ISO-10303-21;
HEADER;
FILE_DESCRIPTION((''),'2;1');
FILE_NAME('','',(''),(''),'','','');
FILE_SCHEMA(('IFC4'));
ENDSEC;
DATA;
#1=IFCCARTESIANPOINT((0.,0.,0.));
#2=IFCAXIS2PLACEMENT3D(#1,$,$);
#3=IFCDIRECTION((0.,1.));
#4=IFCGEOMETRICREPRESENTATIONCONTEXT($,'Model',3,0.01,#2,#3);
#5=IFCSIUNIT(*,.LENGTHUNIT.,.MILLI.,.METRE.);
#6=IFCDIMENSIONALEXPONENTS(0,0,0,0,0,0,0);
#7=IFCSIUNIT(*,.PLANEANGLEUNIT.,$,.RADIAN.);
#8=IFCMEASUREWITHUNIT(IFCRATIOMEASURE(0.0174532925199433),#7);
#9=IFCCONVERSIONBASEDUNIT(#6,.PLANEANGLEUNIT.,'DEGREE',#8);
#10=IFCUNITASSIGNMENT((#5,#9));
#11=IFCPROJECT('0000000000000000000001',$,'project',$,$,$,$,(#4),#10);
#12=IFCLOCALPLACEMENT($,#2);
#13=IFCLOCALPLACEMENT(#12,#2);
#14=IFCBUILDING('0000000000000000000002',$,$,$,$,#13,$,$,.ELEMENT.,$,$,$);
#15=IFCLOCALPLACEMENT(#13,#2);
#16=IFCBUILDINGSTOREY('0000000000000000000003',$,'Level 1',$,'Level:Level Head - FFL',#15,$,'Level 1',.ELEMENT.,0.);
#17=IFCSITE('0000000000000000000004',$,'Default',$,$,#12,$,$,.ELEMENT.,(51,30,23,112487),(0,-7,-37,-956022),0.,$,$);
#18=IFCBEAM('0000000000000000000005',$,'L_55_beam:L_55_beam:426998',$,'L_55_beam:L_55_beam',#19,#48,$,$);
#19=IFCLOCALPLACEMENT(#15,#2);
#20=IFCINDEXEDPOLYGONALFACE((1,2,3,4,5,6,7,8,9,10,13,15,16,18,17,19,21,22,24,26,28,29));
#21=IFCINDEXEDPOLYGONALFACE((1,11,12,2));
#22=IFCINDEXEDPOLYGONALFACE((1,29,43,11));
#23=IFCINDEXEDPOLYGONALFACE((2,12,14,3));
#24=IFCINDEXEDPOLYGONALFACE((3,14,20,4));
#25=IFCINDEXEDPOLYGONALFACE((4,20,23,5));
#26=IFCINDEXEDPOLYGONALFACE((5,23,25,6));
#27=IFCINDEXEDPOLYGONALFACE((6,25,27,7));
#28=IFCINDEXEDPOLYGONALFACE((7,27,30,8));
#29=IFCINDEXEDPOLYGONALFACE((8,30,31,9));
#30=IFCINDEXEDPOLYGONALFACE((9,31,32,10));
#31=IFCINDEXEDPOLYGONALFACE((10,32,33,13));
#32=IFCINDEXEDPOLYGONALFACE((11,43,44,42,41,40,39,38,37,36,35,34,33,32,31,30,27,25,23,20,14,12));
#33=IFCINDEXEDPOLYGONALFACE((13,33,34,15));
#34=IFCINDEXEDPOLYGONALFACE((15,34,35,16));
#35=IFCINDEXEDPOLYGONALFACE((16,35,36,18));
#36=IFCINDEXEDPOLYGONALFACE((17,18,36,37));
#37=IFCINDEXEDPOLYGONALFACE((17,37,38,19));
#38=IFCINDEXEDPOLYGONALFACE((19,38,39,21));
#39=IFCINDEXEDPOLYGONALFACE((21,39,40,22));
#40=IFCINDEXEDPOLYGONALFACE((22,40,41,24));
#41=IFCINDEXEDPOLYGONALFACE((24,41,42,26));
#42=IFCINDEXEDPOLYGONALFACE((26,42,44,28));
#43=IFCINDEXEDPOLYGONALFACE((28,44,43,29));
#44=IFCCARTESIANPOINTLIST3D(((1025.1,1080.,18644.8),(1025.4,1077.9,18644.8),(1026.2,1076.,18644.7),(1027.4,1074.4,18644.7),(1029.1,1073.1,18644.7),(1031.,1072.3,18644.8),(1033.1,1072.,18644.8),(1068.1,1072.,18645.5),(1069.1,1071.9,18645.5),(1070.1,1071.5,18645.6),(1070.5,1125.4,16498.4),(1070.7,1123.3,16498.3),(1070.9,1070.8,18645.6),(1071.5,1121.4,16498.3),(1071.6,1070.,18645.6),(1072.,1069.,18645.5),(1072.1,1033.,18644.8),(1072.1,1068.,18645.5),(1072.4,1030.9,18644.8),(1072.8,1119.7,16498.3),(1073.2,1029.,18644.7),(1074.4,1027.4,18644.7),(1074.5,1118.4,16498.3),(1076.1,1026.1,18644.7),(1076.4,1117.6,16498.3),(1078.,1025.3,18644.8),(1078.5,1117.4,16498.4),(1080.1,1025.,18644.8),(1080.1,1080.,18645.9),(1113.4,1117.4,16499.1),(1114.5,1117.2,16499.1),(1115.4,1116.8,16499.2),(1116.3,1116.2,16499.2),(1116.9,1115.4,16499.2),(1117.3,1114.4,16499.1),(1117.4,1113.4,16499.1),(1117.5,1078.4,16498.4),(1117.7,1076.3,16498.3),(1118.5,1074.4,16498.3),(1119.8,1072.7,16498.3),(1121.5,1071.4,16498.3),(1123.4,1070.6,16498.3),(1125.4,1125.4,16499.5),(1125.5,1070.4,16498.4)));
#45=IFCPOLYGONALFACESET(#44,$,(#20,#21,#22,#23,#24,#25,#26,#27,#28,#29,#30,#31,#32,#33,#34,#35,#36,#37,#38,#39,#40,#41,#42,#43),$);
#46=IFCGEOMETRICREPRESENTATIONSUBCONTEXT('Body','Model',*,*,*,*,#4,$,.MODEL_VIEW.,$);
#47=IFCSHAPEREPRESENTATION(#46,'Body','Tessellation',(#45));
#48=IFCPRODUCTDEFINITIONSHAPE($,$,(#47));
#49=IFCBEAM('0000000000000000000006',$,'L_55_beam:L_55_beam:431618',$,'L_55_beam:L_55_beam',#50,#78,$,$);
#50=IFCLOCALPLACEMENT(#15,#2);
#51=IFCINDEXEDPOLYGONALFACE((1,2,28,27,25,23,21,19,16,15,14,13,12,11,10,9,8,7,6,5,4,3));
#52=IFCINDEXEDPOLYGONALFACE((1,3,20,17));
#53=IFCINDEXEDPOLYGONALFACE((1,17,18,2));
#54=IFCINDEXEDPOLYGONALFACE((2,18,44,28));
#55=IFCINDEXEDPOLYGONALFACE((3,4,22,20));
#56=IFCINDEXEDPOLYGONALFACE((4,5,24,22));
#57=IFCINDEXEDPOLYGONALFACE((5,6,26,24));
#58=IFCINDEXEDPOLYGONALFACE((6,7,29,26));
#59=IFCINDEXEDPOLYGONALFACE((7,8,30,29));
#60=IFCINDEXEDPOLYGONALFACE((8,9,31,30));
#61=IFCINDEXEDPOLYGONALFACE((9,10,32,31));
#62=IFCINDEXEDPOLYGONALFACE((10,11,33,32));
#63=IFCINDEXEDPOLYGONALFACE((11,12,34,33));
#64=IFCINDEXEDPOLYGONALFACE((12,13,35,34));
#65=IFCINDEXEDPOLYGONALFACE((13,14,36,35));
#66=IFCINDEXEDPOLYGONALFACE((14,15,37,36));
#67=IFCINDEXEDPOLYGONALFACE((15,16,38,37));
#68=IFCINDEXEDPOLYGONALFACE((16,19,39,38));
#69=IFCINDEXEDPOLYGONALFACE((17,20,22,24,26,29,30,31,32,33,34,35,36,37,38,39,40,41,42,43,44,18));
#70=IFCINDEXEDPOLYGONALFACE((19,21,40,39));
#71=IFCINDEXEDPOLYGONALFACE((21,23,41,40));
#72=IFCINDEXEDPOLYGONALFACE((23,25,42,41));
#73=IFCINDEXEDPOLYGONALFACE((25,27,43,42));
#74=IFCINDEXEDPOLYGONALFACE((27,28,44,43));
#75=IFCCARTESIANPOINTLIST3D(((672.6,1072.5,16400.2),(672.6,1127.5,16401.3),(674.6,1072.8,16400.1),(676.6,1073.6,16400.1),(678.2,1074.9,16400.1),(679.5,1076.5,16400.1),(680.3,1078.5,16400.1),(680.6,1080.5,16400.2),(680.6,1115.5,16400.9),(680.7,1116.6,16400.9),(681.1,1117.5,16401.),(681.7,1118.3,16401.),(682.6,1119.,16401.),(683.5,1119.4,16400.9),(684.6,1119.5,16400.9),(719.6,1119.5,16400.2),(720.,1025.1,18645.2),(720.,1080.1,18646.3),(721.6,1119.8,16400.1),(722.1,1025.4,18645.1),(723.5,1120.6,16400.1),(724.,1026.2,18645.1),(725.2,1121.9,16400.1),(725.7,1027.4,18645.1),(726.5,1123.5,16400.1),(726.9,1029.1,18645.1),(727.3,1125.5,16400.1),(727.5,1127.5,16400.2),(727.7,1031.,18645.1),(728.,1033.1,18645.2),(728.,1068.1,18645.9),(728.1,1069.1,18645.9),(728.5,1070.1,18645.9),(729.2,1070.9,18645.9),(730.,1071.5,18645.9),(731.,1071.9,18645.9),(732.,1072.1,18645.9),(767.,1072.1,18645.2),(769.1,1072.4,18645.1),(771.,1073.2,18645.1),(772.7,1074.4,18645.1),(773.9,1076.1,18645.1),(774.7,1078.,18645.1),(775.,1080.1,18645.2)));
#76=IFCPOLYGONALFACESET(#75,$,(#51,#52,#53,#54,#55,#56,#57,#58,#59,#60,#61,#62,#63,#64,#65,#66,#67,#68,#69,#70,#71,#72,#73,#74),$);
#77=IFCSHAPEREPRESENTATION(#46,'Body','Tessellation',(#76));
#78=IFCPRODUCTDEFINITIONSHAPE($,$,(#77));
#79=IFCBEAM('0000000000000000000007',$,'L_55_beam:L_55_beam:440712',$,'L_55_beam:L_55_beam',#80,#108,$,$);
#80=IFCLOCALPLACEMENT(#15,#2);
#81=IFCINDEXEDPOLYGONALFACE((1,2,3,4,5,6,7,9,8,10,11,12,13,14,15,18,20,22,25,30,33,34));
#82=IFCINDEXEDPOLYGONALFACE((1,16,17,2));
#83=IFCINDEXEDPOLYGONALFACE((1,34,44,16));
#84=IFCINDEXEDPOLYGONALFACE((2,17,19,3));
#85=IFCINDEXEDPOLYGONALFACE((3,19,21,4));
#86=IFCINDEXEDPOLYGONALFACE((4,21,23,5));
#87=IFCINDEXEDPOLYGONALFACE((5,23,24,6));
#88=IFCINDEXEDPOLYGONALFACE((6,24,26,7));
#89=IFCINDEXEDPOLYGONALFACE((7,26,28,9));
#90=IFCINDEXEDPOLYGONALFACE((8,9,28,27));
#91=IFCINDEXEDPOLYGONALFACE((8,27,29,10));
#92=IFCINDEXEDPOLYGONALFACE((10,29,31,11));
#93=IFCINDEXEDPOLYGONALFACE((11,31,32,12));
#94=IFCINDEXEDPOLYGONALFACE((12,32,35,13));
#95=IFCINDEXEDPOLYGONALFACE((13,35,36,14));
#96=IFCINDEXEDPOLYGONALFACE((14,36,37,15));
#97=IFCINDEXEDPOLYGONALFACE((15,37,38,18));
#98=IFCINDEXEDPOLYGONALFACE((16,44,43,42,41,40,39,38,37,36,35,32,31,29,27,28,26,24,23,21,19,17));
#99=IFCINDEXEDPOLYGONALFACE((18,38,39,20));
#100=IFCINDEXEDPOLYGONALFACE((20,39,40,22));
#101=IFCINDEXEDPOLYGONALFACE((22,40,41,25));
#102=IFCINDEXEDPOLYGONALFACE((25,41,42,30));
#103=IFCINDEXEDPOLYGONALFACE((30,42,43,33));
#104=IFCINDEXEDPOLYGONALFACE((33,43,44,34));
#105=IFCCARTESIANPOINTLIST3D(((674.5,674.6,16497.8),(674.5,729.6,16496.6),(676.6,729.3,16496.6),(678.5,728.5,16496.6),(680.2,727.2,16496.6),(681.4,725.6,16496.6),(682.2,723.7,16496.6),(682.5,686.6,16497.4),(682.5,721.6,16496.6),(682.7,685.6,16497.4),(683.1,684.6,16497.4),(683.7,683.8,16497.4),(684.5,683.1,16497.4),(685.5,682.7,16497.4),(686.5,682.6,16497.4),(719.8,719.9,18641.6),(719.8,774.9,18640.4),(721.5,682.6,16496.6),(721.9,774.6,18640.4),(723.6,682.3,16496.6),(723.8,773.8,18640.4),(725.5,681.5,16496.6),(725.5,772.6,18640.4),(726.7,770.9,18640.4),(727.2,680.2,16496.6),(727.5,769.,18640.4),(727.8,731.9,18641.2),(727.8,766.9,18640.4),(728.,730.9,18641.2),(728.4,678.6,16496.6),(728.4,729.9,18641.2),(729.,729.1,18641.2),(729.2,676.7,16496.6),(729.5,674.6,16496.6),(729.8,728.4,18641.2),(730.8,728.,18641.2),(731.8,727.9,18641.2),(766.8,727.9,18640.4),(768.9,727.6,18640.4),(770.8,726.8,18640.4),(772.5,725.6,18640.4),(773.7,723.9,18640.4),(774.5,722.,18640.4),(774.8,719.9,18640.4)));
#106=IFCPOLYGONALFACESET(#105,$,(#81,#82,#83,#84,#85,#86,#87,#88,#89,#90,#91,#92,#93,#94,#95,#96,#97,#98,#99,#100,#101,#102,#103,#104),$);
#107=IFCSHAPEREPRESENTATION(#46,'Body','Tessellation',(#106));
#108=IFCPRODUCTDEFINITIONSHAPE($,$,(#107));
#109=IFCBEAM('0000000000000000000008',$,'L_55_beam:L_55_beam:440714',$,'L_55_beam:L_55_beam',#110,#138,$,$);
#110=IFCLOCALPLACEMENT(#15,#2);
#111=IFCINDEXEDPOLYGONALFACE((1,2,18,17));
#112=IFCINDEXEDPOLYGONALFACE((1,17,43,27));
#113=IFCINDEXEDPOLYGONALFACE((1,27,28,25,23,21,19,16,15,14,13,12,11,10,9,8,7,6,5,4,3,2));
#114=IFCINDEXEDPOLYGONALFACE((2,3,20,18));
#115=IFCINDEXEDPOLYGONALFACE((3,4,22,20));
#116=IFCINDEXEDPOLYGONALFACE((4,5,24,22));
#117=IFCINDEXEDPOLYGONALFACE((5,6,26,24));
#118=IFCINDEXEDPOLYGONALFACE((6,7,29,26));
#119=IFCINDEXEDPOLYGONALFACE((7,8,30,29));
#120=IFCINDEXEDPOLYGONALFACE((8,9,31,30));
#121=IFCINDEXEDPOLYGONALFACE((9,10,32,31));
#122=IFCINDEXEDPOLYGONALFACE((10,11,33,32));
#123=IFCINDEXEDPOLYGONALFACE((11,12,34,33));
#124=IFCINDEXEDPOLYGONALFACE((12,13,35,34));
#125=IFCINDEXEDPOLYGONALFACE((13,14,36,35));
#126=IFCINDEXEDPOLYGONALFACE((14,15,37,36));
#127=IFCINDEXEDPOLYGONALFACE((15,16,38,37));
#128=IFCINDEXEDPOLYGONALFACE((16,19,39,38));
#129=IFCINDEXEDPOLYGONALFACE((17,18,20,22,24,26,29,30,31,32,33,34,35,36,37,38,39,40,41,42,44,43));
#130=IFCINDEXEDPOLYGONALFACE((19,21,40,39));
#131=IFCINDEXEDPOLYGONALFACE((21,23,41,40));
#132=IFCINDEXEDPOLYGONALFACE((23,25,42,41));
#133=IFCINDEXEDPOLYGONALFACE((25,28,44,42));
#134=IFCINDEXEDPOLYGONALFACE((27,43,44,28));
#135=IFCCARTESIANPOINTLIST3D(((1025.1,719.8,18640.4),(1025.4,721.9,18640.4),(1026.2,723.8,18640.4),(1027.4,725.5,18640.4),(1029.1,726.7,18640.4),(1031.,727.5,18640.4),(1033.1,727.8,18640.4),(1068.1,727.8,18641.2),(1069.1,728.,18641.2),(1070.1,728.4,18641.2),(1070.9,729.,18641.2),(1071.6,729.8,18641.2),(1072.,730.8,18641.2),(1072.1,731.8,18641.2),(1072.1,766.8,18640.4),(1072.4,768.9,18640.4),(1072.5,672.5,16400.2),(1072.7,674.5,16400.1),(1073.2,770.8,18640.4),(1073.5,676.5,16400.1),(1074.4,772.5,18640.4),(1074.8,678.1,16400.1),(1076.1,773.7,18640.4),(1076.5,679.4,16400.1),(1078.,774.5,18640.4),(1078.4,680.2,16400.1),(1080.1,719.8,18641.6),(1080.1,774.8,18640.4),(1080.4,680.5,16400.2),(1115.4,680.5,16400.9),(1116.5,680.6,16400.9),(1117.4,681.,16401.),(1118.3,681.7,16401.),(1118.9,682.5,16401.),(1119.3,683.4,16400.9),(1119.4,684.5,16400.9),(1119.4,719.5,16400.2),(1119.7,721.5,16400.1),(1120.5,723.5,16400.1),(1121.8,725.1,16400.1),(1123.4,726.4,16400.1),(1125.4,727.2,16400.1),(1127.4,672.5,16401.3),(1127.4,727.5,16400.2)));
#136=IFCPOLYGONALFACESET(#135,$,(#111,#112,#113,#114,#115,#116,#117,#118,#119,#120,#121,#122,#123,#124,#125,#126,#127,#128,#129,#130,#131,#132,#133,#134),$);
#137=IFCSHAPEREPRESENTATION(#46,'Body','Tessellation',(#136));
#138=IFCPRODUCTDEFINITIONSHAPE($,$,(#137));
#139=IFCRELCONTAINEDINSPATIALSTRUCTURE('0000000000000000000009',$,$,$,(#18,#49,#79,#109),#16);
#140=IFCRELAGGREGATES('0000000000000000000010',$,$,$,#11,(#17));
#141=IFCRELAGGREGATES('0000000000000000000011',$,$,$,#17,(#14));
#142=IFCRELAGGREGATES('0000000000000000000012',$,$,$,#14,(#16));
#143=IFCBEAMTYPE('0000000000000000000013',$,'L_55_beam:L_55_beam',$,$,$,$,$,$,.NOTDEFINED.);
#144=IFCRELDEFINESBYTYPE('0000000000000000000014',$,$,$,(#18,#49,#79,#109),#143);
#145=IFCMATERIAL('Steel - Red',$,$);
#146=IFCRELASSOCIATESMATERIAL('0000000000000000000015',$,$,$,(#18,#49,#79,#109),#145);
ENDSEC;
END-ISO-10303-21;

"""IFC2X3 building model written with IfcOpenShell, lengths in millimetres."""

from ifc_helpers import new_model, entity, si_unit, converted_unit, direction, frame, frame_2d, origin, place, context, subcontext, project, spatial, polyline, circle_curve, parameter, trimmed, segment, composite_curve, outline, extrude, material, type_object, element, save


model = new_model("IFC2X3")

# Units and contexts
model_context = context("Model", 3, precision=0.01, world=origin(), true_north=direction((0.0, 1.0)))
body_context = subcontext(model_context, "Body", "Model", "MODEL_VIEW")
ifc_project = project(units=[si_unit("LENGTHUNIT", "METRE", prefix="MILLI"), converted_unit("PLANEANGLEUNIT", "DEGREE", entity("IfcRatioMeasure", 0.0174532925199433), si_unit("PLANEANGLEUNIT", "RADIAN"), dimensions=[0, 0, 0, 0, 0, 0, 0])], contexts=[model_context])

# Site, building, storey
site_placement = place(None, origin())
site = spatial("IfcSite", under=ifc_project, at=site_placement, Name="Default", CompositionType="ELEMENT", RefLatitude=(51, 30, 23, 112487), RefLongitude=(0, -7, -37, -956022), RefElevation=0.0)
building_placement = place(site_placement, origin())
building = spatial("IfcBuilding", under=site, at=building_placement, CompositionType="ELEMENT")
storey_placement = place(building_placement, origin())
storey = spatial("IfcBuildingStorey", under=building, at=storey_placement, Name="Level 1", ObjectType="Level:Level Head - FFL", LongName="Level 1", CompositionType="ELEMENT", Elevation=0.0)

# Beams
ifc_material_1 = material(Name="Steel - Red")
beam_type_1 = type_object("IfcBeamType", Name="L_55_beam:L_55_beam", PredefinedType="NOTDEFINED")
beam_1_placement = place(storey_placement, frame((1080.1, 1080.0, 18645.9), z_axis=(0.999777, -0.000446, 0.021115), x_axis=(0.02112, 0.021125, -0.999554)))
element("IfcBeam", 1, at=beam_1_placement, inside=storey, type_object=beam_type_1, material=ifc_material_1, Name="L_55_beam:L_55_beam:426998", ObjectType="L_55_beam:L_55_beam", context=body_context, shape_type="SweptSolid", body=[
    extrude(outline(composite_curve([segment(polyline([(-36.4, -18.6), (18.6, -18.6)]), True, "CONTINUOUS"), segment(polyline([(18.6, -18.6), (18.6, 36.4)]), True, "CONTINUOUS"), segment(trimmed(circle_curve(frame_2d((18.6, 28.4), x_axis=(0.0, 1.0)), 8.0), [parameter(0.0)], [parameter(90.0)], True, "PARAMETER"), True, "CONTINUOUS"), segment(polyline([(10.6, 28.4), (10.6, -6.6)]), True, "CONTINUOUS"), segment(trimmed(circle_curve(frame_2d((6.6, -6.6), x_axis=(1.0, 0.0)), 4.0), [parameter(270.0)], [parameter(0.0)], True, "PARAMETER"), False, "CONTINUOUS"), segment(polyline([(6.6, -10.6), (-28.4, -10.6)]), True, "CONTINUOUS"), segment(trimmed(circle_curve(frame_2d((-28.4, -18.6), x_axis=(0.0, 1.0)), 8.0), [parameter(0.0)], [parameter(90.0)], True, "PARAMETER"), True, "CONTINUOUS")], self_intersect=False)), frame((0.0, -18.6, -18.6), z_axis=(1.0, 0.0, 0.0), x_axis=(0.0, 0.000332, 1.0)), (0.0, 0.0, 1.0), 2147.4),
])
beam_2_placement = place(storey_placement, frame((720.0, 1080.1, 18645.9), z_axis=(0.999777, 0.000446, -0.02112), x_axis=(-0.021125, 0.02112, -0.999554)))
element("IfcBeam", 2, at=beam_2_placement, inside=storey, type_object=beam_type_1, material=ifc_material_1, Name="L_55_beam:L_55_beam:431618", ObjectType="L_55_beam:L_55_beam", context=body_context, shape_type="SweptSolid", body=[
    extrude(outline(composite_curve([segment(polyline([(-18.6, -18.6), (36.4, -18.6)]), True, "CONTINUOUS"), segment(trimmed(circle_curve(frame_2d((28.4, -18.6), x_axis=(1.0, 0.0)), 8.0), [parameter(0.0)], [parameter(90.0)], True, "PARAMETER"), True, "CONTINUOUS"), segment(polyline([(28.4, -10.6), (-6.6, -10.6)]), True, "CONTINUOUS"), segment(trimmed(circle_curve(frame_2d((-6.6, -6.6), x_axis=(0.0, -1.0)), 4.0), [parameter(270.0)], [parameter(0.0)], True, "PARAMETER"), False, "CONTINUOUS"), segment(polyline([(-10.6, -6.6), (-10.6, 28.4)]), True, "CONTINUOUS"), segment(trimmed(circle_curve(frame_2d((-18.6, 28.4), x_axis=(1.0, 0.0)), 8.0), [parameter(0.0)], [parameter(90.0)], True, "PARAMETER"), True, "CONTINUOUS"), segment(polyline([(-18.6, 36.4), (-18.6, -18.6)]), True, "CONTINUOUS")], self_intersect=False)), frame((-0.4, -18.6, 18.6), z_axis=(1.0, 0.0, 0.0), x_axis=(0.0, -0.000112, 1.0)), (0.0, 0.0, 1.0), 2246.0),
])
beam_3_placement = place(storey_placement, frame((719.9, 720.0, 18645.9), z_axis=(0.999777, -0.000446, -0.021115), x_axis=(-0.02112, -0.021125, -0.999554)))
element("IfcBeam", 3, at=beam_3_placement, inside=storey, type_object=beam_type_1, material=ifc_material_1, Name="L_55_beam:L_55_beam:440712", ObjectType="L_55_beam:L_55_beam", context=body_context, shape_type="SweptSolid", body=[
    extrude(outline(composite_curve([segment(polyline([(-6.6, 10.6), (28.4, 10.6)]), True, "CONTINUOUS"), segment(trimmed(circle_curve(frame_2d((28.4, 18.6), x_axis=(0.0, -1.0)), 8.0), [parameter(0.0)], [parameter(90.0)], True, "PARAMETER"), True, "CONTINUOUS"), segment(polyline([(36.4, 18.6), (-18.6, 18.6)]), True, "CONTINUOUS"), segment(polyline([(-18.6, 18.6), (-18.6, -36.4)]), True, "CONTINUOUS"), segment(trimmed(circle_curve(frame_2d((-18.6, -28.4), x_axis=(0.0, -1.0)), 8.0), [parameter(0.0)], [parameter(90.0)], True, "PARAMETER"), True, "CONTINUOUS"), segment(polyline([(-10.6, -28.4), (-10.6, 6.6)]), True, "CONTINUOUS"), segment(trimmed(circle_curve(frame_2d((-6.6, 6.6), x_axis=(-1.0, 0.0)), 4.0), [parameter(270.0)], [parameter(0.0)], True, "PARAMETER"), False, "CONTINUOUS")], self_intersect=False)), frame((4.4, 18.6, 18.6), z_axis=(1.0, 0.0, 0.0), x_axis=(0.0, 0.000332, 1.0)), (0.0, 0.0, 1.0), 2144.8),
])
beam_4_placement = place(storey_placement, frame((1080.0, 719.9, 18645.9), z_axis=(0.999777, 0.000446, 0.02112), x_axis=(0.021125, -0.02112, -0.999554)))
element("IfcBeam", 4, at=beam_4_placement, inside=storey, type_object=beam_type_1, material=ifc_material_1, Name="L_55_beam:L_55_beam:440714", ObjectType="L_55_beam:L_55_beam", context=body_context, shape_type="SweptSolid", body=[
    extrude(outline(composite_curve([segment(polyline([(-36.4, -18.6), (18.6, -18.6)]), True, "CONTINUOUS"), segment(polyline([(18.6, -18.6), (18.6, 36.4)]), True, "CONTINUOUS"), segment(trimmed(circle_curve(frame_2d((18.6, 28.4), x_axis=(0.0, 1.0)), 8.0), [parameter(0.0)], [parameter(90.0)], True, "PARAMETER"), True, "CONTINUOUS"), segment(polyline([(10.6, 28.4), (10.6, -6.6)]), True, "CONTINUOUS"), segment(trimmed(circle_curve(frame_2d((6.6, -6.6), x_axis=(1.0, 0.0)), 4.0), [parameter(270.0)], [parameter(0.0)], True, "PARAMETER"), False, "CONTINUOUS"), segment(polyline([(6.6, -10.6), (-28.4, -10.6)]), True, "CONTINUOUS"), segment(trimmed(circle_curve(frame_2d((-28.4, -18.6), x_axis=(0.0, 1.0)), 8.0), [parameter(0.0)], [parameter(90.0)], True, "PARAMETER"), True, "CONTINUOUS")], self_intersect=False)), frame((4.4, 18.6, -18.6), z_axis=(1.0, 0.0, 0.0), x_axis=(0.0, -1.0, -0.000112)), (0.0, 0.0, 1.0), 2241.2),
])

save(model, "model.ifc")
